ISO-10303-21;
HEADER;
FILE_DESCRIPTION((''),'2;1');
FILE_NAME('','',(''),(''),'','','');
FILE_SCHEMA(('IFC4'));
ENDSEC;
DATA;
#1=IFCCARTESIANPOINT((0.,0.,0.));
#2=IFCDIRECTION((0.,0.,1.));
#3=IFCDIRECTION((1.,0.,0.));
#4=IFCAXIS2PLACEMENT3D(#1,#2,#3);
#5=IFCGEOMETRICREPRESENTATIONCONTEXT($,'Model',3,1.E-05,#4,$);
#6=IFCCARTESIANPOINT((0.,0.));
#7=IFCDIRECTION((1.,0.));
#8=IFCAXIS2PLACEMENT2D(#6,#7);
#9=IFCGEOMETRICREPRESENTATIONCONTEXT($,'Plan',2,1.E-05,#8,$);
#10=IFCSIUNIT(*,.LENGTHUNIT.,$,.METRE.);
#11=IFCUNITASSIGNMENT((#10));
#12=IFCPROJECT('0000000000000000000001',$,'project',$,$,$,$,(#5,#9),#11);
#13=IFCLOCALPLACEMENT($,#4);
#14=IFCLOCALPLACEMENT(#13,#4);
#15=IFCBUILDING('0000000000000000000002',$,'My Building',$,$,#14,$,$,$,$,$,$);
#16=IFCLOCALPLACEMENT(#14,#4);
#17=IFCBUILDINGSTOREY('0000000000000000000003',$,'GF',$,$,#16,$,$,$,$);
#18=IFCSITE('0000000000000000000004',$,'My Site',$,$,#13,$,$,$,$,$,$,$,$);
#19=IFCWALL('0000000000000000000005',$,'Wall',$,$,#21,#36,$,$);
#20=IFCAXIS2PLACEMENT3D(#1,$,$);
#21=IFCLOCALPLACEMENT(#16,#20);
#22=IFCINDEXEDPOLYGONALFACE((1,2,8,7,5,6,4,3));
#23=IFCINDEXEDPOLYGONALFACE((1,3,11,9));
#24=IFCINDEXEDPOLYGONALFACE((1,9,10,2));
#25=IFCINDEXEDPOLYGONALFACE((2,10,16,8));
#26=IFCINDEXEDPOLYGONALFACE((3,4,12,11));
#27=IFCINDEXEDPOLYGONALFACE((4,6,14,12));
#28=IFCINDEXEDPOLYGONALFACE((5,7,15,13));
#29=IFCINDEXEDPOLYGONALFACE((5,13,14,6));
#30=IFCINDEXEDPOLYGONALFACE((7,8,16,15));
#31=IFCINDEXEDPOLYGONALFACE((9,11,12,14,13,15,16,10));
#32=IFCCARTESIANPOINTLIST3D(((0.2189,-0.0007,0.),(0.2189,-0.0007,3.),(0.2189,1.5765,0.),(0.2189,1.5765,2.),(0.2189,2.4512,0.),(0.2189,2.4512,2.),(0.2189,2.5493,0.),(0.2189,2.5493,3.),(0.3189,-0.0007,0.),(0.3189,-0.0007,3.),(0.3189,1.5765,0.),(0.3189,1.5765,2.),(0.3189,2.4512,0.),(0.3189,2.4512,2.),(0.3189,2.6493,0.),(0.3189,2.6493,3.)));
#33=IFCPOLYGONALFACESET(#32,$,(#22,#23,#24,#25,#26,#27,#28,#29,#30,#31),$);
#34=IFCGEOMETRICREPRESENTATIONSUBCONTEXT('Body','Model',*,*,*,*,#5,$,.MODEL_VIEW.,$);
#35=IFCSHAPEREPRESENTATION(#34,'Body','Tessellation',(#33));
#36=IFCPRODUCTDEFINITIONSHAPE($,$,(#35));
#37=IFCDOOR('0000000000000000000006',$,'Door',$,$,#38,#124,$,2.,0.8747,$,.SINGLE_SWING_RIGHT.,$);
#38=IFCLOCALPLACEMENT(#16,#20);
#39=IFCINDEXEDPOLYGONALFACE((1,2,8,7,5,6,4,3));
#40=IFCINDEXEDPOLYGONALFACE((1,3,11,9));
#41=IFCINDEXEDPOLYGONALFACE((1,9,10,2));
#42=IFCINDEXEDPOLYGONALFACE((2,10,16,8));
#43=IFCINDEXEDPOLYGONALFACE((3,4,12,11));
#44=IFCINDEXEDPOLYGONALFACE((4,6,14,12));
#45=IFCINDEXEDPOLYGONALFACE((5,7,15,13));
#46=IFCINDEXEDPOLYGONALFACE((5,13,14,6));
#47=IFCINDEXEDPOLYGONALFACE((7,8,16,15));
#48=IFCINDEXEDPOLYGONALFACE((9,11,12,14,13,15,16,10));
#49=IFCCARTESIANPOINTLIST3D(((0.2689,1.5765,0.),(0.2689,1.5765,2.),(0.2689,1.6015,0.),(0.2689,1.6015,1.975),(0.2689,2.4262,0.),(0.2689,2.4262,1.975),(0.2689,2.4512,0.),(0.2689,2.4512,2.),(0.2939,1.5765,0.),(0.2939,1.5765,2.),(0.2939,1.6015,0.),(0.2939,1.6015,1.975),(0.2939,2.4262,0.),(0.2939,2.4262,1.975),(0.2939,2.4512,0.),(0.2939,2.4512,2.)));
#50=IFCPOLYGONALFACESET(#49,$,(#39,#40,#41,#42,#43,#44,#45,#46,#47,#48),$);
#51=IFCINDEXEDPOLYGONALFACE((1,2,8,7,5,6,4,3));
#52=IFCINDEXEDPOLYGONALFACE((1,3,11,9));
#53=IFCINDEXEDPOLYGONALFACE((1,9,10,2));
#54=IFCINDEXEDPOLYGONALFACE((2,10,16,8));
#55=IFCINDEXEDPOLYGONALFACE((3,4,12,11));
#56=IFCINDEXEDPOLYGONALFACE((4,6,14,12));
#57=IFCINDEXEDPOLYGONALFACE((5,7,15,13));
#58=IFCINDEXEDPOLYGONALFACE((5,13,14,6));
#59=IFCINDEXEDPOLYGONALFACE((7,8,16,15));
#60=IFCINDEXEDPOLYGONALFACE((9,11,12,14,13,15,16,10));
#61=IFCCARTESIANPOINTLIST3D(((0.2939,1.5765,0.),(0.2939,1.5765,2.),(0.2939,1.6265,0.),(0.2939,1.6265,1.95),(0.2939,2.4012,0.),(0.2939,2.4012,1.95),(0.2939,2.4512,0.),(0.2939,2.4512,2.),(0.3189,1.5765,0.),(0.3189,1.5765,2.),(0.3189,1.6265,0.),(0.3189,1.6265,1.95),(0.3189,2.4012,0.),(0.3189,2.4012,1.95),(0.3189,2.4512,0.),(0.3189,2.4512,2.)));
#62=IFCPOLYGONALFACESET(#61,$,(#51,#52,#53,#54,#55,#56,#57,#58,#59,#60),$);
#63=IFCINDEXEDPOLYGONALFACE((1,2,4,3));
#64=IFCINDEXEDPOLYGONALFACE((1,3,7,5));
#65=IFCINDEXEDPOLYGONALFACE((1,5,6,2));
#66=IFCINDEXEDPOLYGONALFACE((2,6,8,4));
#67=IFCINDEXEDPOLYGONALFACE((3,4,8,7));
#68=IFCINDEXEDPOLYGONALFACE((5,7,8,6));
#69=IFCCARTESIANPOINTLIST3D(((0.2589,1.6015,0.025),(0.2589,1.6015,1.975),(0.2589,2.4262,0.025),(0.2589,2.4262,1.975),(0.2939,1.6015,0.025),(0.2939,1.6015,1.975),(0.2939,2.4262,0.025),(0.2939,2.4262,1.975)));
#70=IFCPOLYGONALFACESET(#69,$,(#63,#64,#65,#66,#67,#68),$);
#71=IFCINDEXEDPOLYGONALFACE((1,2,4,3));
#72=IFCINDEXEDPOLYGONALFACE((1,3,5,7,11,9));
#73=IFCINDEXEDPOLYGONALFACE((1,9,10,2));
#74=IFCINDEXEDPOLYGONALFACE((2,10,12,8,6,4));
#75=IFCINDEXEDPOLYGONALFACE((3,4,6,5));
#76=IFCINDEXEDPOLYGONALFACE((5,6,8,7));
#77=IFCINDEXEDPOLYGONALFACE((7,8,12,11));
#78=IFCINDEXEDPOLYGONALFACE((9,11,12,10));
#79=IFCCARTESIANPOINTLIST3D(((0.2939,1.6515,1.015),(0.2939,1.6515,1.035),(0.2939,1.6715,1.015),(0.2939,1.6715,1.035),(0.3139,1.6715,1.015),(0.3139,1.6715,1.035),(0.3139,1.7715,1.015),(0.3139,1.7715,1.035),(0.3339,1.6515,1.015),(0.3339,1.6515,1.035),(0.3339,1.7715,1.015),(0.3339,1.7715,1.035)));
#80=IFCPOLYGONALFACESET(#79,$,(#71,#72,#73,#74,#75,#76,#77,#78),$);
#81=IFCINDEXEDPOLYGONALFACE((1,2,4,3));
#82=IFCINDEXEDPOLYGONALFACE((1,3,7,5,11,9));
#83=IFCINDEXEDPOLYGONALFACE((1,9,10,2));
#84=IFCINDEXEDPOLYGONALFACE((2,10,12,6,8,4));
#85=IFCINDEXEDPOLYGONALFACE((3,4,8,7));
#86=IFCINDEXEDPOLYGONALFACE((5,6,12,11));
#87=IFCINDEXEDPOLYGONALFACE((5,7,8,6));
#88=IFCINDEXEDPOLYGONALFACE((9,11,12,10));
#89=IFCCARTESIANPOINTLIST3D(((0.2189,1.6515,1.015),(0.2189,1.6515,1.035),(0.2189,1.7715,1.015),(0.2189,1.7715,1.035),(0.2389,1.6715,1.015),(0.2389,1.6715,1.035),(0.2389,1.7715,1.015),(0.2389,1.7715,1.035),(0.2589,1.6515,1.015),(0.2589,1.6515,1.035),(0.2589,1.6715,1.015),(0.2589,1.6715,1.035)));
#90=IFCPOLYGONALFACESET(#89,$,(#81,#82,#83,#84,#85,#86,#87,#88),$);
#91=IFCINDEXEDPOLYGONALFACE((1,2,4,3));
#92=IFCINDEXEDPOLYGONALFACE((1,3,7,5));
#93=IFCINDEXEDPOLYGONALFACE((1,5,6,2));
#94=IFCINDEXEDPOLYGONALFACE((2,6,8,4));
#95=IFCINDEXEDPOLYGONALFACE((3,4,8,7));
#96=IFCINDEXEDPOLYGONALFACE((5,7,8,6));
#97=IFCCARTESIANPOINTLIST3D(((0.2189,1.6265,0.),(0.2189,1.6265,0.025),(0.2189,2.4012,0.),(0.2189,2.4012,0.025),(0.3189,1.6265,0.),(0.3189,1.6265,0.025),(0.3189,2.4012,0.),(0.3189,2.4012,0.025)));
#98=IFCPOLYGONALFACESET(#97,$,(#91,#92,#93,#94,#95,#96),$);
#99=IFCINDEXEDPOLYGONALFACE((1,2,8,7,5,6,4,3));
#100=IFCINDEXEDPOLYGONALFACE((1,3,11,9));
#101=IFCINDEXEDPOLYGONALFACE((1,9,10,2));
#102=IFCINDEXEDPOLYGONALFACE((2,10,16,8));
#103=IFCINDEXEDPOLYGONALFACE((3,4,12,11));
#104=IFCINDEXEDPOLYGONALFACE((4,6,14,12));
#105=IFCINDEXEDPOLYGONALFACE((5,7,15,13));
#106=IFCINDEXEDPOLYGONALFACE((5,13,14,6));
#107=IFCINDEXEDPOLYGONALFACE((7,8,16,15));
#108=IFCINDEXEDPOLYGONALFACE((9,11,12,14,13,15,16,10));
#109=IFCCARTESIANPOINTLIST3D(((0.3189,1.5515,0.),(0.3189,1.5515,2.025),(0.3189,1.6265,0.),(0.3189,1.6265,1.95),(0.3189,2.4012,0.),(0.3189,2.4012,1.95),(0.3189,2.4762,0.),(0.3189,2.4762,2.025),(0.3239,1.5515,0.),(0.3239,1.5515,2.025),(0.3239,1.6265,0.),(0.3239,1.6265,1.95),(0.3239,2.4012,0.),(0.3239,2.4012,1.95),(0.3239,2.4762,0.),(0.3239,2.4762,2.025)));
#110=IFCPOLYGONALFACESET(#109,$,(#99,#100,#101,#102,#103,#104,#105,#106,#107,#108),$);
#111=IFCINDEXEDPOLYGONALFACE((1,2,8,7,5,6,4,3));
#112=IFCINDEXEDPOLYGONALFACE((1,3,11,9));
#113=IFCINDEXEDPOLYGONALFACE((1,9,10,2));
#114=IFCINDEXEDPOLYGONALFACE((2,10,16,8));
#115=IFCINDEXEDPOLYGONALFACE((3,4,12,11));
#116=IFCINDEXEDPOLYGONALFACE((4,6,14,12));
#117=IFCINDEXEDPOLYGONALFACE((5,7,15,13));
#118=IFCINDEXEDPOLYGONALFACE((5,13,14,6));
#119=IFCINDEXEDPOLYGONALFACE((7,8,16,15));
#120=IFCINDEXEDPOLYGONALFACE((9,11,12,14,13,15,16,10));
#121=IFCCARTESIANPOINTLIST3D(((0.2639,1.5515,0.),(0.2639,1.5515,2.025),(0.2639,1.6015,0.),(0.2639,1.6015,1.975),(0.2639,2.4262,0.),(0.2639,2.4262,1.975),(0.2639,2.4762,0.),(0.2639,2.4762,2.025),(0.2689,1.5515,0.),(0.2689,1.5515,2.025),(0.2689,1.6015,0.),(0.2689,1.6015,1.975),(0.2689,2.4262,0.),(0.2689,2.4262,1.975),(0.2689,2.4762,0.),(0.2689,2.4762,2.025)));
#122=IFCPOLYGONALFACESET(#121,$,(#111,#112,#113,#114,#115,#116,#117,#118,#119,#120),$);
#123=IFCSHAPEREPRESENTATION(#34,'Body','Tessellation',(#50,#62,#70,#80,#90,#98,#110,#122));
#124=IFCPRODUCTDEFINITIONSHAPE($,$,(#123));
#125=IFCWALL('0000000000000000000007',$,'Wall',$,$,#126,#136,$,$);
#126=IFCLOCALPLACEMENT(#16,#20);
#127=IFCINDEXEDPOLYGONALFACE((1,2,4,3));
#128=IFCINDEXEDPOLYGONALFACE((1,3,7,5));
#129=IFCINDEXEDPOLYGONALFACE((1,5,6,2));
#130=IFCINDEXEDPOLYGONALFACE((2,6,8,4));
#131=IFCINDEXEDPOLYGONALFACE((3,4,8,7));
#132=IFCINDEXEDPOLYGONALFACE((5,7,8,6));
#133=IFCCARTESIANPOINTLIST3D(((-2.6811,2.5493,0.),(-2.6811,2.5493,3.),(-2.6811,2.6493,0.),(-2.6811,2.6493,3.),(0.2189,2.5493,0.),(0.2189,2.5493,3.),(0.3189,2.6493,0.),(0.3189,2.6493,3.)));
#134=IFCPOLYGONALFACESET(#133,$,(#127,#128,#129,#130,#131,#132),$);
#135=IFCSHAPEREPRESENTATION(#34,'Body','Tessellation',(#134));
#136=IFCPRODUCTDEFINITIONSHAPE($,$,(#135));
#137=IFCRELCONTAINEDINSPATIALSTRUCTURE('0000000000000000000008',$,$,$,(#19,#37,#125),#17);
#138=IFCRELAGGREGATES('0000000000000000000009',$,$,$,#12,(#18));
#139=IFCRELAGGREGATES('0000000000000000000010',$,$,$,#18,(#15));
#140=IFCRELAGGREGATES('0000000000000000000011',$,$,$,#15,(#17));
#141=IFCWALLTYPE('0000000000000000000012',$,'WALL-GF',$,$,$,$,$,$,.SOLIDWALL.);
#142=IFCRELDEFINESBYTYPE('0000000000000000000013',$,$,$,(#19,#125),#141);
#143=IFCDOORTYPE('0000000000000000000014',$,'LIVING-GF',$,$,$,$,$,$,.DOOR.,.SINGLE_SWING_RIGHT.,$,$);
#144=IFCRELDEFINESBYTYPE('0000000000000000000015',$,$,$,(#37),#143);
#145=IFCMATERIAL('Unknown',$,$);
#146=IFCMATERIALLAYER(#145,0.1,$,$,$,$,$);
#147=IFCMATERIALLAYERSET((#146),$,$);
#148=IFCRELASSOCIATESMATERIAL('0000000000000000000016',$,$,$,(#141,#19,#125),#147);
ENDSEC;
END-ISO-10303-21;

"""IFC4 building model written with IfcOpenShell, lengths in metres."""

from ifc_helpers import new_model, entity, si_unit, frame, origin_with_axes, origin_2d_with_axis, place, context, subcontext, project, spatial, line, indexed_curve, outline, extrude, shape, source, transform, mapped, material, layer, layer_set, layer_usage, type_object, type_shapes, element, fill, save


model = new_model("IFC4")

# Units and contexts
model_context = context("Model", 3, precision=1e-05, world=origin_with_axes())
plan_context = context("Plan", 2, precision=1e-05, world=origin_2d_with_axis())
body_context_1 = subcontext(model_context, "Body", "Model", "MODEL_VIEW")
body_context_2 = subcontext(plan_context, "Body", "Plan", "PLAN_VIEW")
ifc_project = project(units=[si_unit("LENGTHUNIT", "METRE")], contexts=[model_context, plan_context])

# Site, building, storey
site_placement = place(None, origin_with_axes())
site = spatial("IfcSite", under=ifc_project, at=site_placement, Name="My Site")
building_placement = place(site_placement, origin_with_axes())
building = spatial("IfcBuilding", under=site, at=building_placement, Name="My Building")
storey_placement = place(building_placement, origin_with_axes())
storey = spatial("IfcBuildingStorey", under=building, at=storey_placement, Name="GF")

# Shared definitions
ifc_material_1 = material(Name="Unknown")

# Shared definitions
ifc_layer_1 = layer(ifc_material_1, 0.1)
ifc_layer_set_1 = layer_set([ifc_layer_1])
wall_type = type_object("IfcWallType", Name="WALL-GF", PredefinedType="SOLIDWALL", material=ifc_layer_set_1)

# Wall, opening, door
ifc_layer_usage_1 = layer_usage(ifc_layer_set_1, "AXIS2", "POSITIVE", 0.0)
wall_1_placement = place(storey_placement, frame((0.3189, -0.0007, 0.0), z_axis=(0.0, 0.0, 1.0), x_axis=(0.0, 1.0, 0.0)))
wall_1 = element("IfcWall", 1, at=wall_1_placement, inside=storey, type_object=wall_type, material=ifc_layer_usage_1, Name="Wall", context=body_context_1, shape_type="SweptSolid", body=[
    extrude(outline(indexed_curve([(0.0, 0.0), (0.0, 0.1), (2.55, 0.1), (2.65, 0.0)], segments=[line(1, 2, 3, 4, 1)])), origin_with_axes(), (0.0, 0.0, 1.0), 3.0),
])
shared_shape_1 = source(origin_with_axes(), body_context_1, "Body", "SweptSolid", [
    extrude(outline(indexed_curve([(0.0, 0.0), (0.8747, 0.0), (0.8747, 2.0), (0.0, 2.0)], segments=[line(1, 2, 3, 4, 1)])), frame((0.0, -0.6, 0.0), z_axis=(0.0, -1.0, 0.0), x_axis=(1.0, 0.0, 0.0)), (0.0, 0.0, -1.0), 1.2),
])
opening_1_placement = place(wall_1_placement, frame((1.5772, 0.0, 0.0), z_axis=(0.0, 0.0, 1.0), x_axis=(1.0, 0.0, 0.0)))
opening_1 = element("IfcOpeningElement", 2, at=opening_1_placement, cuts=wall_1, PredefinedType="OPENING", context=body_context_1, shape_type="MappedRepresentation", body=[
    mapped(shared_shape_1, transform((0.0, 0.0, 0.0), x_axis=(1.0, 0.0, 0.0), y_axis=(0.0, 1.0, 0.0), z_axis=(0.0, 0.0, 1.0), scale=1.0)),
])
door_type_1 = type_object("IfcDoorType", Name="LIVING-GF", OperationType="SINGLE_SWING_RIGHT", PredefinedType="DOOR")
shared_shape_2 = source(origin_with_axes(), body_context_1, "Body", "SweptSolid", [
    extrude(outline(indexed_curve([(0.0, 0.0), (0.0, 2.0), (0.8747, 2.0), (0.8747, 0.0), (0.8497, 0.0), (0.8497, 1.975), (0.025, 1.975), (0.025, 0.0)], segments=[line(1, 2, 3, 4, 5, 6, 7, 8, 1)])), frame((0.0, 0.025, 0.0), z_axis=(0.0, -1.0, 0.0), x_axis=(1.0, 0.0, 0.0)), (0.0, 0.0, -1.0), 0.025),
    extrude(outline(indexed_curve([(0.0, 0.0), (0.0, 2.0), (0.8747, 2.0), (0.8747, 0.0), (0.8247, 0.0), (0.8247, 1.95), (0.05, 1.95), (0.05, 0.0)], segments=[line(1, 2, 3, 4, 5, 6, 7, 8, 1)])), frame((0.0, 0.0, 0.0), z_axis=(0.0, -1.0, 0.0), x_axis=(1.0, 0.0, 0.0)), (0.0, 0.0, -1.0), 0.025),
    extrude(outline(indexed_curve([(0.0, 0.0), (0.8247, 0.0), (0.8247, 0.035), (0.0, 0.035)], segments=[line(1, 2, 3, 4, 1)])), frame((0.025, 0.025, 0.025), z_axis=(0.0, 0.0, 1.0), x_axis=(1.0, 0.0, 0.0)), (0.0, 0.0, 1.0), 1.95),
    extrude(outline(indexed_curve([(0.0, 0.0), (0.0, -0.04), (0.12, -0.04), (0.12, -0.02), (0.02, -0.02), (0.02, 0.0)], segments=[line(1, 2, 3, 4, 5, 6, 1)])), frame((0.075, 0.025, 1.015), z_axis=(0.0, 0.0, 1.0), x_axis=(1.0, 0.0, 0.0)), (0.0, 0.0, 1.0), 0.02),
    extrude(outline(indexed_curve([(0.0, 0.0), (0.0, 0.04), (0.12, 0.04), (0.12, 0.02), (0.02, 0.02), (0.02, 0.0)], segments=[line(1, 2, 3, 4, 5, 6, 1)])), frame((0.075, 0.06, 1.015), z_axis=(0.0, 0.0, 1.0), x_axis=(1.0, 0.0, 0.0)), (0.0, 0.0, 1.0), 0.02),
    extrude(outline(indexed_curve([(0.0, 0.0), (0.7747, 0.0), (0.7747, 0.1), (0.0, 0.1)], segments=[line(1, 2, 3, 4, 1)])), frame((0.05, 0.0, 0.0), z_axis=(0.0, 0.0, 1.0), x_axis=(1.0, 0.0, 0.0)), (0.0, 0.0, 1.0), 0.025),
    extrude(outline(indexed_curve([(0.0, 0.0), (0.0, 2.025), (0.9247, 2.025), (0.9247, 0.0), (0.8497, 0.0), (0.8497, 1.95), (0.075, 1.95), (0.075, 0.0)], segments=[line(1, 2, 3, 4, 5, 6, 7, 8, 1)])), frame((-0.025, -0.005, 0.0), z_axis=(0.0, -1.0, 0.0), x_axis=(1.0, 0.0, 0.0)), (0.0, 0.0, -1.0), 0.005),
    extrude(outline(indexed_curve([(0.0, 0.0), (0.0, 2.025), (0.9247, 2.025), (0.9247, 0.0), (0.8747, 0.0), (0.8747, 1.975), (0.05, 1.975), (0.05, 0.0)], segments=[line(1, 2, 3, 4, 5, 6, 7, 8, 1)])), frame((-0.025, 0.05, 0.0), z_axis=(0.0, -1.0, 0.0), x_axis=(1.0, 0.0, 0.0)), (0.0, 0.0, -1.0), 0.005),
])
shared_shape_3 = source(origin_with_axes(), body_context_2, "Body", "Curve2D", [
    entity("IfcIndexedPolyCurve", entity("IfcCartesianPointList2D", [[0.0, 0.0], [0.0, 0.05], [0.025, 0.05], [0.025, 0.025], [0.05, 0.025], [0.05, 0.0]]), [entity("IfcLineIndex", [1, 2, 3, 4, 5, 6, 1])]),
    entity("IfcIndexedPolyCurve", entity("IfcCartesianPointList2D", [[0.8747, 0.0], [0.8747, 0.05], [0.8497, 0.05], [0.8497, 0.025], [0.8247, 0.025], [0.8247, 0.0]]), [entity("IfcLineIndex", [1, 2, 3, 4, 5, 6, 1])]),
    entity("IfcTrimmedCurve", entity("IfcEllipse", entity("IfcAxis2Placement2D", entity("IfcCartesianPoint", [0.8147, 0.05]), entity("IfcDirection", [1.0, 0.0])), 0.7897, 0.8247), [entity("IfcCartesianPoint", [0.8147, 0.8747])], [entity("IfcCartesianPoint", [0.025, 0.05])], True, "CARTESIAN"),
    entity("IfcIndexedPolyCurve", entity("IfcCartesianPointList2D", [[0.8497, 0.05], [0.8147, 0.05], [0.8147, 0.8747], [0.8497, 0.8747]]), [entity("IfcLineIndex", [1, 2, 3, 4, 1])]),
])
type_shapes(door_type_1, [shared_shape_2, shared_shape_3])
door_1_placement = place(opening_1_placement, frame((0.0, 0.0, 0.0), z_axis=(0.0, 0.0, 1.0), x_axis=(1.0, 0.0, 0.0)))
door_1 = element("IfcDoor", 3, at=door_1_placement, inside=storey, type_object=door_type_1, Name="Door", OperationType="SINGLE_SWING_RIGHT", OverallHeight=2.0, OverallWidth=0.8747, shapes=[
    shape(body_context_1, "Body", "MappedRepresentation", [mapped(shared_shape_2, transform((0.0, 0.0, 0.0), x_axis=(1.0, 0.0, 0.0), y_axis=(0.0, 1.0, 0.0), z_axis=(0.0, 0.0, 1.0), scale=1.0))]),
    shape(body_context_2, "Body", "MappedRepresentation", [mapped(shared_shape_3, transform((0.0, 0.0, 0.0), x_axis=(1.0, 0.0, 0.0), y_axis=(0.0, 1.0, 0.0), z_axis=(0.0, 0.0, 1.0), scale=1.0))]),
])
fill(opening_1, door_1)

# Wall
ifc_layer_usage_2 = layer_usage(ifc_layer_set_1, "AXIS2", "POSITIVE", 0.0)
wall_2_placement = place(storey_placement, frame((0.3189, 2.6493, 0.0), z_axis=(0.0, 0.0, 1.0), x_axis=(-1.0, 0.0, 0.0)))
element("IfcWall", 4, at=wall_2_placement, inside=storey, type_object=wall_type, material=ifc_layer_usage_2, Name="Wall", context=body_context_1, shape_type="SweptSolid", body=[
    extrude(outline(indexed_curve([(0.0, 0.0), (0.1, 0.1), (3.0, 0.1), (3.0, 0.0)], segments=[line(1, 2, 3, 4, 1)])), origin_with_axes(), (0.0, 0.0, 1.0), 3.0),
])

save(model, "model.ifc")
